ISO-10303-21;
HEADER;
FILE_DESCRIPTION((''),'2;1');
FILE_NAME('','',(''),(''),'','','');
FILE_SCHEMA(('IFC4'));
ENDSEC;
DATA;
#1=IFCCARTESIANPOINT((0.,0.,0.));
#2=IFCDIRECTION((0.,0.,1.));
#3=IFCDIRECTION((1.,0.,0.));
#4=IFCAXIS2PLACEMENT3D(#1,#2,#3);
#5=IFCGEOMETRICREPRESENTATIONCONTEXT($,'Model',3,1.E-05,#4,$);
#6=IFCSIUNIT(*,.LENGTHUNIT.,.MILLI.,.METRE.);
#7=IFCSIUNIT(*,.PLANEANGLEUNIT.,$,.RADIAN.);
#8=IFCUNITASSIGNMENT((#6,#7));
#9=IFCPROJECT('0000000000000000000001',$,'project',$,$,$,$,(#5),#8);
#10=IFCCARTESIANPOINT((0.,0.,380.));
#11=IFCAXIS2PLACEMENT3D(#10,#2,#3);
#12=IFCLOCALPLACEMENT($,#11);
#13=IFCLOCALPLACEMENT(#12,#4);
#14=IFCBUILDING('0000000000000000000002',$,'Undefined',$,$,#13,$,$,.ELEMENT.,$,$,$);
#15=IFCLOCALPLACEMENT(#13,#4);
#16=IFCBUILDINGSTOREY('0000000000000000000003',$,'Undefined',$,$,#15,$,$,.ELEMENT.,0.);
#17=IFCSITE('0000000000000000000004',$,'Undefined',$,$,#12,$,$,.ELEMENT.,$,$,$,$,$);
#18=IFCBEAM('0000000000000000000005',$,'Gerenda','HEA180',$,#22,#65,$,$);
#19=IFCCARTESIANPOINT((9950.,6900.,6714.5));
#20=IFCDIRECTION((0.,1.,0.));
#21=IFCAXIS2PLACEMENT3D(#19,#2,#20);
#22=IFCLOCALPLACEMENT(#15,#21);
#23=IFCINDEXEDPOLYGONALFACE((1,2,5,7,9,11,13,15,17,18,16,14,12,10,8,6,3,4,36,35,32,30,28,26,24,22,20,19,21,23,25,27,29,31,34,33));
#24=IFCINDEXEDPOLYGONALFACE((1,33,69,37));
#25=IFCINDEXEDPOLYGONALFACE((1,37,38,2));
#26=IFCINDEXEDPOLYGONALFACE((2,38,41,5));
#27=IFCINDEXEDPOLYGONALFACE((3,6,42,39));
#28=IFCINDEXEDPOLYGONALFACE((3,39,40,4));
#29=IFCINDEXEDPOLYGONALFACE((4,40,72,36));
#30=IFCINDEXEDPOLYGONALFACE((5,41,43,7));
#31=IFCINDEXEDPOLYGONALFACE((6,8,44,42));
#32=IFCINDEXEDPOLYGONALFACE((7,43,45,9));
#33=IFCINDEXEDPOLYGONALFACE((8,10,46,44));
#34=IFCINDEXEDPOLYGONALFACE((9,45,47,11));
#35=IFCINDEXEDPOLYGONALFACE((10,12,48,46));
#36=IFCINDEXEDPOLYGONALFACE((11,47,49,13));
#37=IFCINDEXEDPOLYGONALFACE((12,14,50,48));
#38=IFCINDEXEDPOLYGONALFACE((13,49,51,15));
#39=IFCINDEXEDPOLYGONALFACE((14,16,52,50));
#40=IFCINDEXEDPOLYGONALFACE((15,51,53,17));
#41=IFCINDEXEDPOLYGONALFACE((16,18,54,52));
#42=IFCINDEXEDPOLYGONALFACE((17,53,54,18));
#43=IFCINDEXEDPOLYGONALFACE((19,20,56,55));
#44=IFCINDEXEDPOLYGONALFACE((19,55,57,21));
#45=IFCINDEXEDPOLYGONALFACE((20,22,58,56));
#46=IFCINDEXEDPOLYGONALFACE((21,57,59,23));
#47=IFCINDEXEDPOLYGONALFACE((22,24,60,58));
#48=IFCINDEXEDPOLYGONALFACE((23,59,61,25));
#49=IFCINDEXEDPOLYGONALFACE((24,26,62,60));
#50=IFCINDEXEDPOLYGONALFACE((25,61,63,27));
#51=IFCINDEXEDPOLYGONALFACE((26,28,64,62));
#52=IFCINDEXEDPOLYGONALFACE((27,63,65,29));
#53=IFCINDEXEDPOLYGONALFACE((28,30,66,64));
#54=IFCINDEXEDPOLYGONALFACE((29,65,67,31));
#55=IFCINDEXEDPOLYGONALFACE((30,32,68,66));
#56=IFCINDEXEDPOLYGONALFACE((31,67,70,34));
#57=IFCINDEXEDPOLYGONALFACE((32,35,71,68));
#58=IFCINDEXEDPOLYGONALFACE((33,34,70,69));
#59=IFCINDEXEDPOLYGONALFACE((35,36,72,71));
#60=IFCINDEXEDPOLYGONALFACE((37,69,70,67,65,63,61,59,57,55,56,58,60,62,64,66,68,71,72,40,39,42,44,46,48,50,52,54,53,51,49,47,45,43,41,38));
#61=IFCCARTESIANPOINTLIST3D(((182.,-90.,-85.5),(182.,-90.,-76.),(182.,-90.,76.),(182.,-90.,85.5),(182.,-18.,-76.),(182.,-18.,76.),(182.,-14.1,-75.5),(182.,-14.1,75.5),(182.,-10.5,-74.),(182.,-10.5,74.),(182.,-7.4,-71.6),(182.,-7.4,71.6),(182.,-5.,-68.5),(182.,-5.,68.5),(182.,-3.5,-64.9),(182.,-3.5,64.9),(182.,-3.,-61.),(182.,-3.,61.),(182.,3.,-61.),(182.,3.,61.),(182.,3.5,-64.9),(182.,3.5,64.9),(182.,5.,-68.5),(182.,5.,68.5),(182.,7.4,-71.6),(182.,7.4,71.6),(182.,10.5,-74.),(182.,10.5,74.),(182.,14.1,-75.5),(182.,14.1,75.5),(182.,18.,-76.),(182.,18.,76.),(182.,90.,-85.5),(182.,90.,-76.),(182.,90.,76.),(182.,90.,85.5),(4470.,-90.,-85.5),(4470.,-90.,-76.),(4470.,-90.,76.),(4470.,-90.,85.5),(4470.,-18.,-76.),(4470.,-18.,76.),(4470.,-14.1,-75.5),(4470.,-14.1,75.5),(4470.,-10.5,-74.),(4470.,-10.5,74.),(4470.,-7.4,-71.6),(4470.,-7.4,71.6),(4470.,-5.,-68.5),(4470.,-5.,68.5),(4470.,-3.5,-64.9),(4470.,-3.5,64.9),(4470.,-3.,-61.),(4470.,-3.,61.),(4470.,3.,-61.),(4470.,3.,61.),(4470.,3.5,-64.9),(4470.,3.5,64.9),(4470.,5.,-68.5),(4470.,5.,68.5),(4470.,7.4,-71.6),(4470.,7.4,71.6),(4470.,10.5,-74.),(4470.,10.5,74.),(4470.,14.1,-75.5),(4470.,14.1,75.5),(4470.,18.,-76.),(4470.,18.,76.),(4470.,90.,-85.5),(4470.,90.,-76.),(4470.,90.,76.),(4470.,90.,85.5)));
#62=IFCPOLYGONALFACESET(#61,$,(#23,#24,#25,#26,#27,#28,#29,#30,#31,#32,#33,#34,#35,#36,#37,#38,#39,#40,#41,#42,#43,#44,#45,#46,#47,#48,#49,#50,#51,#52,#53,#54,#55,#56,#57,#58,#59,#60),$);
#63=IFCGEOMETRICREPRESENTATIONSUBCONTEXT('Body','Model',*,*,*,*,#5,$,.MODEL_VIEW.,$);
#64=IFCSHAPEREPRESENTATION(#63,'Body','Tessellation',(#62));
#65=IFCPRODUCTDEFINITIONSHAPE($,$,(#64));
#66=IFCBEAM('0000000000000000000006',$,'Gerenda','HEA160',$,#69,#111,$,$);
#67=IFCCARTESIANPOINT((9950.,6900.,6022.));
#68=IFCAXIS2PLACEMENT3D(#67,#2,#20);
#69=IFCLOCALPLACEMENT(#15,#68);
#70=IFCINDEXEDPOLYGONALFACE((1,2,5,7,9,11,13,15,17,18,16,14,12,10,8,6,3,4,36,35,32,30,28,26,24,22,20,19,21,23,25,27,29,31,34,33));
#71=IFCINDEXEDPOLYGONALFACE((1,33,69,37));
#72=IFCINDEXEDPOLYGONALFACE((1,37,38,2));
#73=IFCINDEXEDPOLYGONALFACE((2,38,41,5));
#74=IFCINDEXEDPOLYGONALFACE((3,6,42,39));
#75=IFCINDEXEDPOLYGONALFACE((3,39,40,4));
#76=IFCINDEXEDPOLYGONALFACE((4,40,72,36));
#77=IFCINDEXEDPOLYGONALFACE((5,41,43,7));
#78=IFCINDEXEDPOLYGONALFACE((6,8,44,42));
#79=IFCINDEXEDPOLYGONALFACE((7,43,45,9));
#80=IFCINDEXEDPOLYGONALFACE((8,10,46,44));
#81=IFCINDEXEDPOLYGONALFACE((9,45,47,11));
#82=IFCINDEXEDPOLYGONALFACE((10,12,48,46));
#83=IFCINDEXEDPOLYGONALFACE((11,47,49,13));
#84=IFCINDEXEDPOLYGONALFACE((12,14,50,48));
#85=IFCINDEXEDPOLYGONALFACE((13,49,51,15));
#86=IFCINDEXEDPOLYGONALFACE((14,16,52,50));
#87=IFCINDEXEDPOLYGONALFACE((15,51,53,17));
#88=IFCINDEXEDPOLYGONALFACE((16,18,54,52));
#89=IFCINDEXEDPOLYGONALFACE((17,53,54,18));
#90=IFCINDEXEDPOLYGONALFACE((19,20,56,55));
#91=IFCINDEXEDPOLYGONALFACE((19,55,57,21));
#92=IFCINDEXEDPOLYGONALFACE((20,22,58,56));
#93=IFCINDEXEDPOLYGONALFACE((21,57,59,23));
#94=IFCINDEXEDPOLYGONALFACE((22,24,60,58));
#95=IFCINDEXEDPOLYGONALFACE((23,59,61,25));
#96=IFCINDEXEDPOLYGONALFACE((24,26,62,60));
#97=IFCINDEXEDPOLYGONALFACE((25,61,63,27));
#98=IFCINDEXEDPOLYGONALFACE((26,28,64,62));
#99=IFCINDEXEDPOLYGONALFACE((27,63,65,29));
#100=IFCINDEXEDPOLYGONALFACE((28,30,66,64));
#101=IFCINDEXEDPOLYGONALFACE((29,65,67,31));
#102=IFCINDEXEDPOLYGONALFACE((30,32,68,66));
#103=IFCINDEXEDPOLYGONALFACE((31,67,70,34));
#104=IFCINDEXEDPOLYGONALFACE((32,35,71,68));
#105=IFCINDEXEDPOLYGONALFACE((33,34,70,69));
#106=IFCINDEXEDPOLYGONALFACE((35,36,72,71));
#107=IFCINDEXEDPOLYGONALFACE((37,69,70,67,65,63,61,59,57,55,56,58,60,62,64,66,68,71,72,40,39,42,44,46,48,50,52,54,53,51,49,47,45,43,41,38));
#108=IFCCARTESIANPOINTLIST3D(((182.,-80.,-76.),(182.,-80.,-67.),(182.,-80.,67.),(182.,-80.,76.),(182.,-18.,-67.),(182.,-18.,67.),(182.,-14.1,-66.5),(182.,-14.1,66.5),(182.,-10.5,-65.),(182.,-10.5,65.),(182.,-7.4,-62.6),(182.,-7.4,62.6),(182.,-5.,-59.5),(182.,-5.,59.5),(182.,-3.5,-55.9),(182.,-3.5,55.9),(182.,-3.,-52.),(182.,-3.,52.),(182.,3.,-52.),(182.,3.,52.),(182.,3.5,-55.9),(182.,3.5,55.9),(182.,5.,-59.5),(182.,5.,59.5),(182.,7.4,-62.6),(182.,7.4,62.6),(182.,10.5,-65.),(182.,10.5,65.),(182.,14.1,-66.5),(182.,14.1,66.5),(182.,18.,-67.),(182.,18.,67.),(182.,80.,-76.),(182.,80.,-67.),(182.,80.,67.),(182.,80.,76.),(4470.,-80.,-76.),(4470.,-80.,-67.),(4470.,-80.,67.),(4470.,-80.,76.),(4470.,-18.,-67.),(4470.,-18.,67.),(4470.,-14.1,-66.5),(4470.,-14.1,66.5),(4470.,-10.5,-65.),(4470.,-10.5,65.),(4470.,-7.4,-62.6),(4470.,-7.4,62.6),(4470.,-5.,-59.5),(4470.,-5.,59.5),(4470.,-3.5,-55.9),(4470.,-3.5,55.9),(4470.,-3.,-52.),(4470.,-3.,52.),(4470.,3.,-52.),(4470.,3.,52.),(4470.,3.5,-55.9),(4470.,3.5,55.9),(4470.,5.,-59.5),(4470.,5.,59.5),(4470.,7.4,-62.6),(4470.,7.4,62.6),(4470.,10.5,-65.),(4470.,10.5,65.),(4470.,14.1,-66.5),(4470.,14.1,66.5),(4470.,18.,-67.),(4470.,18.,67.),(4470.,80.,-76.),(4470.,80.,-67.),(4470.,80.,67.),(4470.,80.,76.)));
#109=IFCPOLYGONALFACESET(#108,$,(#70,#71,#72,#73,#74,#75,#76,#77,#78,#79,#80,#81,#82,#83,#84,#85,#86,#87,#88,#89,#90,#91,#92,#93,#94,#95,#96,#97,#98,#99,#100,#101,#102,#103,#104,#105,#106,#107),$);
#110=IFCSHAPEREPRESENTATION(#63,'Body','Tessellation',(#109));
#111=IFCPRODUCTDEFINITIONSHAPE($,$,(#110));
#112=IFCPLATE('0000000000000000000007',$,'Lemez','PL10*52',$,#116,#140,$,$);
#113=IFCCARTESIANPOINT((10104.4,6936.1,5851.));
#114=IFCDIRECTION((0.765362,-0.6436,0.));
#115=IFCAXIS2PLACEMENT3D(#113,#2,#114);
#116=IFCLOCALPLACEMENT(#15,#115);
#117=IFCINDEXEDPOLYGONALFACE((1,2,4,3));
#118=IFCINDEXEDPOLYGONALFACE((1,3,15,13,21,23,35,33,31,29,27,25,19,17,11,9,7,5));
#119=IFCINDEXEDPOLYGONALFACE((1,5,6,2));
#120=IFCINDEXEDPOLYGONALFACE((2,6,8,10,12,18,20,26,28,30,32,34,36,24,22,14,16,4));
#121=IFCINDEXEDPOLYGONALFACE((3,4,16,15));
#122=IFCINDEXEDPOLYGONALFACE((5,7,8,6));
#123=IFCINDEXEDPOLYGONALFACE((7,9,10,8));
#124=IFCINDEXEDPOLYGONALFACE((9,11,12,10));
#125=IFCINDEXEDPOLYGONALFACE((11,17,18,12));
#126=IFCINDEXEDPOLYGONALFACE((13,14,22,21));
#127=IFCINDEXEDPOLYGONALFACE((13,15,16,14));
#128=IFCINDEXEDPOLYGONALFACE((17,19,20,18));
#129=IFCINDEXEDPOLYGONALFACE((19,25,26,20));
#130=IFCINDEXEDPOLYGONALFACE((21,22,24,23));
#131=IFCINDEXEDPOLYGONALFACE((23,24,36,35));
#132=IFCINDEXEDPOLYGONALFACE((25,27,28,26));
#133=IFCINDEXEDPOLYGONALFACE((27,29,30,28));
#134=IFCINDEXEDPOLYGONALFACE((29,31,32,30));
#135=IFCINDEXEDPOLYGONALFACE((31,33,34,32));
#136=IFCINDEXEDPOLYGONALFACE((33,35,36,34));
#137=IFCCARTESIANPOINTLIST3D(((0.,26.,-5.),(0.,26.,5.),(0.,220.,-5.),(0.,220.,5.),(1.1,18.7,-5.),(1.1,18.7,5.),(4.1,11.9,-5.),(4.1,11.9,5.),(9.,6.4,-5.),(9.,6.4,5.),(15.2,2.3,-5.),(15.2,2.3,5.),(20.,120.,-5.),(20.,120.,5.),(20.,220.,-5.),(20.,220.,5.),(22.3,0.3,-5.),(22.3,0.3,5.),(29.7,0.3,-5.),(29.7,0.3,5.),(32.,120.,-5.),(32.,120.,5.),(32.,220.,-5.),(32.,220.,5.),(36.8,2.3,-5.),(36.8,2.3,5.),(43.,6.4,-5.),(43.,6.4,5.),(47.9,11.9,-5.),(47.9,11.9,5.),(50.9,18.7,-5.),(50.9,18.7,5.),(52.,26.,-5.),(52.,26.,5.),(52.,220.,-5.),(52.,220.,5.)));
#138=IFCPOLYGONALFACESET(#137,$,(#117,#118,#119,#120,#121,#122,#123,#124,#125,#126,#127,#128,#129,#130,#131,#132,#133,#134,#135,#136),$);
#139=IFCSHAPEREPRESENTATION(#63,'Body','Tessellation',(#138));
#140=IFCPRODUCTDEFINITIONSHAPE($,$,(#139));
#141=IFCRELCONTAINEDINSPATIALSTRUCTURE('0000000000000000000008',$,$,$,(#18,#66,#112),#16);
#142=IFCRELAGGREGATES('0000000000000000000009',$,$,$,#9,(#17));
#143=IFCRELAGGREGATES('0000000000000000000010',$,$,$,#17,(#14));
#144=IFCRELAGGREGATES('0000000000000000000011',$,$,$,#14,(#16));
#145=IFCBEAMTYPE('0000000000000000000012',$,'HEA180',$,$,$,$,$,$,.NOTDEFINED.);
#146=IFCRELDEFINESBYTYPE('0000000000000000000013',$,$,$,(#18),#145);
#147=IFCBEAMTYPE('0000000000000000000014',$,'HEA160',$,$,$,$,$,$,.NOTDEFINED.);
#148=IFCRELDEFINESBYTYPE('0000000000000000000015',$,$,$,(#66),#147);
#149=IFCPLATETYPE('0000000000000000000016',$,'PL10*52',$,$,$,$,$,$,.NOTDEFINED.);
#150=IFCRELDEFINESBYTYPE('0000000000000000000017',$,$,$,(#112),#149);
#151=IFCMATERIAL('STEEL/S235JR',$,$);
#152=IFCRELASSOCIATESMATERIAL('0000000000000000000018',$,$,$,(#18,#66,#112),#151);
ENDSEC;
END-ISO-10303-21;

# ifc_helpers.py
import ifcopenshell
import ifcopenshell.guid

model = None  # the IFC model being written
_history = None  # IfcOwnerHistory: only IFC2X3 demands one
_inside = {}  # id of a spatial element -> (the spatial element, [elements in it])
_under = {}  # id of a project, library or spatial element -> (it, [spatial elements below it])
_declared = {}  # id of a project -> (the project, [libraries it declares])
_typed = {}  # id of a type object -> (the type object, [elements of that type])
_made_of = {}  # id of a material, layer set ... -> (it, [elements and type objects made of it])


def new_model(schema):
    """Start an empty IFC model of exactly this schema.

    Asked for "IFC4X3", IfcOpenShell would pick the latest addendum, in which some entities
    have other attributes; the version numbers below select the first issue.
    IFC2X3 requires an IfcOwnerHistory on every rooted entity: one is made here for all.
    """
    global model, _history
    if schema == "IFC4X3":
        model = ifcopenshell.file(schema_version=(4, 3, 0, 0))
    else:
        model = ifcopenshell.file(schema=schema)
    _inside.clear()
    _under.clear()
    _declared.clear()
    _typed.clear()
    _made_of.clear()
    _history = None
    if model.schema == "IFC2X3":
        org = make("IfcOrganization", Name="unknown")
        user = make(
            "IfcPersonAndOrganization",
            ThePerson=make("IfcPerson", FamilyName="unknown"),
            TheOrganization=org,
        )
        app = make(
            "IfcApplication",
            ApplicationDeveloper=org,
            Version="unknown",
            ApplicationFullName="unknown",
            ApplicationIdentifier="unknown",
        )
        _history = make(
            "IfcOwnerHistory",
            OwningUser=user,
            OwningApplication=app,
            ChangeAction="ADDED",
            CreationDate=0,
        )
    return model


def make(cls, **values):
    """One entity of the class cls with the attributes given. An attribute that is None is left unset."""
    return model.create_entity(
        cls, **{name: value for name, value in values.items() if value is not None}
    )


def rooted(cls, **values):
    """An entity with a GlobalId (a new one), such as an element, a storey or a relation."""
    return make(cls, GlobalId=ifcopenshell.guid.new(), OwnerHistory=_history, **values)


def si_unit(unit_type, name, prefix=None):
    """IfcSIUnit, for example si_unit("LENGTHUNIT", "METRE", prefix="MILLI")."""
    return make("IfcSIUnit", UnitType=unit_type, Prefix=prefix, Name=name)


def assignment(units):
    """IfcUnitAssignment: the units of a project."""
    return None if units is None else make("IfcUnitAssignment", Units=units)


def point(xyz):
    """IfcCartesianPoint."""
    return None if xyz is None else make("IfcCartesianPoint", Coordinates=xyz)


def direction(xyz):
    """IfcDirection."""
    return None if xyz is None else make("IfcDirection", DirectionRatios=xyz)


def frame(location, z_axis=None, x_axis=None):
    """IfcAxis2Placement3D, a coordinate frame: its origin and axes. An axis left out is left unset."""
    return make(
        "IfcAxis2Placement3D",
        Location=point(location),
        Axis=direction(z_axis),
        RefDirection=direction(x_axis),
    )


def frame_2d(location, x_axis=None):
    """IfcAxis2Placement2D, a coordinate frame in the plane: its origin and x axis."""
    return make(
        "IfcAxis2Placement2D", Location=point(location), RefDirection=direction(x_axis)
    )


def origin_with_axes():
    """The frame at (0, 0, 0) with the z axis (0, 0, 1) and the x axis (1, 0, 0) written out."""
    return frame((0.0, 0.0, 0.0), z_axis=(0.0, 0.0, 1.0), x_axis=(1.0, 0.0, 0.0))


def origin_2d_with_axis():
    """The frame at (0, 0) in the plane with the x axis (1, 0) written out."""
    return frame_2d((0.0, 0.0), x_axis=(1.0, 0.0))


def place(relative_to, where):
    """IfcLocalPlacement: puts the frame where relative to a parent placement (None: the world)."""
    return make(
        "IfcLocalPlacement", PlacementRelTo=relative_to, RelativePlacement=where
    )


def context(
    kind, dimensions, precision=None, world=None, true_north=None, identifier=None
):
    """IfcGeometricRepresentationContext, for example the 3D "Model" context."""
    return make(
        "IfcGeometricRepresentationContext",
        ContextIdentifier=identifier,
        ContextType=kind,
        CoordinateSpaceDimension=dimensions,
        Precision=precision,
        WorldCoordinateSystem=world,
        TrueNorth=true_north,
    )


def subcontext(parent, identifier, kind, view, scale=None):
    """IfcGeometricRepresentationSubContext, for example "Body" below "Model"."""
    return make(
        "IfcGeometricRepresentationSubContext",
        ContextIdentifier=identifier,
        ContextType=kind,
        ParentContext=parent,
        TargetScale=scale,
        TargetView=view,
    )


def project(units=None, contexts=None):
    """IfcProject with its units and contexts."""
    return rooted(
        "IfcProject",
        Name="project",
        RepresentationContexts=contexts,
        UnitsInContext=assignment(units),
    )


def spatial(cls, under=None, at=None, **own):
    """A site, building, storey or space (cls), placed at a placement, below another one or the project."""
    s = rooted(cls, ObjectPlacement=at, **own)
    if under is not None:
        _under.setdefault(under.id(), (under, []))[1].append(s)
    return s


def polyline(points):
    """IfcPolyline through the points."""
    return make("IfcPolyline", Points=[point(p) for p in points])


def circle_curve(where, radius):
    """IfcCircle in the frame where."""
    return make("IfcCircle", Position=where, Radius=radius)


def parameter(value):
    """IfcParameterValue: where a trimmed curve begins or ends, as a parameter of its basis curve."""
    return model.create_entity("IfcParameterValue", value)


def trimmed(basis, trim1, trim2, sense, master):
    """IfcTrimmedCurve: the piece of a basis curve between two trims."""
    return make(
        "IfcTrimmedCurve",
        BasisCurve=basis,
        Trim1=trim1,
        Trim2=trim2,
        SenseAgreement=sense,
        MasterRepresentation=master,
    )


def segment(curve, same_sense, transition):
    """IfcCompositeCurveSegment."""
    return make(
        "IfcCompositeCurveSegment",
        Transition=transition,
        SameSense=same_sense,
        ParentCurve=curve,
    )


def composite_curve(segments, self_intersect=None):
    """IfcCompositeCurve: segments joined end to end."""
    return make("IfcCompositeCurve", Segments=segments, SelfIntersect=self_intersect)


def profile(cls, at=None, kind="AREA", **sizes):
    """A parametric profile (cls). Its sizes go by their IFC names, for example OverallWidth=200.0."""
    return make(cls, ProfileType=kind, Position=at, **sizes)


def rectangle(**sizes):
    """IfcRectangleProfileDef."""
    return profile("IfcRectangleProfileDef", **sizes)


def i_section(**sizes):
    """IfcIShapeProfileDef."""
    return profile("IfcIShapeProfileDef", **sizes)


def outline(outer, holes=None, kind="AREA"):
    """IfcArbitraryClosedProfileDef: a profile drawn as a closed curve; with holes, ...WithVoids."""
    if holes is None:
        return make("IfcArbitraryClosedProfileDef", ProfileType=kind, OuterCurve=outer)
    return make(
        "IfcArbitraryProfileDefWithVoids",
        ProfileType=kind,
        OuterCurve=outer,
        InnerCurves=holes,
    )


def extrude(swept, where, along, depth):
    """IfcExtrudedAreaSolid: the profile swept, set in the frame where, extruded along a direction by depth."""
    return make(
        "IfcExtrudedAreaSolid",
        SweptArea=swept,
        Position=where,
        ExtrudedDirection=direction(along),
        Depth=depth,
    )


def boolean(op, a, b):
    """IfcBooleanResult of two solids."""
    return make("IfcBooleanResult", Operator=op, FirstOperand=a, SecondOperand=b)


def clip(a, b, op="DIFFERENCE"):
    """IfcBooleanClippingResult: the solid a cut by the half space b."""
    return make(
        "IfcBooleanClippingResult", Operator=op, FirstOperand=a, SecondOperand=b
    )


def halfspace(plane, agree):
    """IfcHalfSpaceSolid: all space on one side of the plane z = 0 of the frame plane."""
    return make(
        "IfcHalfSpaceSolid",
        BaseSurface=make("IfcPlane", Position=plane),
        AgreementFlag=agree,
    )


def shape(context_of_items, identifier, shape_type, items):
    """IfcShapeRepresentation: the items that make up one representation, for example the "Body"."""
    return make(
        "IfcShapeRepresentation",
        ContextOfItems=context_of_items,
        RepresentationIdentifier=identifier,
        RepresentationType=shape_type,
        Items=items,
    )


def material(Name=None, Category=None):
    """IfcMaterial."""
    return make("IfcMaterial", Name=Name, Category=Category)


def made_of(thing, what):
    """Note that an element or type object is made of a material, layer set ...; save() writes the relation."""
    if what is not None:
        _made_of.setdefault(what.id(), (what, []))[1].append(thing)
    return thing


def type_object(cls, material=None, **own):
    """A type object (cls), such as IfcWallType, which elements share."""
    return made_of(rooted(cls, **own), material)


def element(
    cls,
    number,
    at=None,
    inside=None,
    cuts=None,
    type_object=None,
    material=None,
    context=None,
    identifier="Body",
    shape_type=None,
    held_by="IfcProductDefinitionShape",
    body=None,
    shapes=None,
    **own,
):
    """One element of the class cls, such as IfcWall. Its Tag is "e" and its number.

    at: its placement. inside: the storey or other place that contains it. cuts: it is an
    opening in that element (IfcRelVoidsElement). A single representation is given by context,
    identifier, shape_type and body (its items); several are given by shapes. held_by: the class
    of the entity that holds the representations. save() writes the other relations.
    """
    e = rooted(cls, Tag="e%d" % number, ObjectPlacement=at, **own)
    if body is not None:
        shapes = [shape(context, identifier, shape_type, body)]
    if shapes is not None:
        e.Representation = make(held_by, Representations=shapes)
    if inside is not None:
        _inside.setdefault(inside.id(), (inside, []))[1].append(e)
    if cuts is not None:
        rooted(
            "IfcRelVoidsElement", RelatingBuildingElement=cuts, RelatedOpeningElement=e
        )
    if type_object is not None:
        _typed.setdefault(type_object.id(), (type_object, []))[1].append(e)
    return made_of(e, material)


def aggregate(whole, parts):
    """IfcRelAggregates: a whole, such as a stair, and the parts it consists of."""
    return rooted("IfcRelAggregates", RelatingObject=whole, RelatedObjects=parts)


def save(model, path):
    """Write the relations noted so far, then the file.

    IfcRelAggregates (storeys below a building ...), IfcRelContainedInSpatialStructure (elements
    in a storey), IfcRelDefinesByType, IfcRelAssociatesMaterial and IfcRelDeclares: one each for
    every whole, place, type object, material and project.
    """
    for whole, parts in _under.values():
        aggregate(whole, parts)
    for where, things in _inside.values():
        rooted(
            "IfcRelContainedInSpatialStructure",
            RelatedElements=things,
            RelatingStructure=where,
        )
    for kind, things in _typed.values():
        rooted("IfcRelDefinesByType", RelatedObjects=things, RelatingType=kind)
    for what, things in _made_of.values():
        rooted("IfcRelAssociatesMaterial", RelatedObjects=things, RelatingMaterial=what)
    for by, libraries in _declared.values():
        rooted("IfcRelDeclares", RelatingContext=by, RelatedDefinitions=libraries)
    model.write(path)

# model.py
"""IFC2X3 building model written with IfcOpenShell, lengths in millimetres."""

from ifc_helpers import new_model, si_unit, frame, frame_2d, origin_with_axes, origin_2d_with_axis, place, context, subcontext, project, spatial, polyline, circle_curve, parameter, trimmed, segment, composite_curve, rectangle, i_section, outline, extrude, boolean, clip, halfspace, material, type_object, element, save


model = new_model("IFC2X3")

# Units and contexts
model_context = context("Model", 3, precision=1e-05, world=origin_with_axes())
body_context = subcontext(model_context, "Body", "Model", "MODEL_VIEW")
ifc_project = project(units=[si_unit("LENGTHUNIT", "METRE", prefix="MILLI"), si_unit("PLANEANGLEUNIT", "RADIAN")], contexts=[model_context])

# Site, building, storey
site_placement = place(None, frame((0.0, 0.0, 380.0), z_axis=(0.0, 0.0, 1.0), x_axis=(1.0, 0.0, 0.0)))
site = spatial("IfcSite", under=ifc_project, at=site_placement, Name="Undefined", CompositionType="ELEMENT")
building_placement = place(site_placement, origin_with_axes())
building = spatial("IfcBuilding", under=site, at=building_placement, Name="Undefined", CompositionType="ELEMENT")
storey_placement = place(building_placement, origin_with_axes())
storey = spatial("IfcBuildingStorey", under=building, at=storey_placement, Name="Undefined", CompositionType="ELEMENT", Elevation=0.0)

# Shared definitions
ifc_material_1 = material(Name="STEEL/S235JR")

# Beams
beam_type_1 = type_object("IfcBeamType", Name="HEA180", PredefinedType="NOTDEFINED")
beam_1_placement = place(storey_placement, frame((9950.0, 6900.0, 6714.5), z_axis=(0.0, 0.0, 1.0), x_axis=(0.0, 1.0, 0.0)))
element("IfcBeam", 1, at=beam_1_placement, inside=storey, type_object=beam_type_1, material=ifc_material_1, Name="Gerenda", Description="HEA180", context=body_context, shape_type="Clipping", body=[
    clip(extrude(i_section(OverallWidth=180.0, OverallDepth=171.0, WebThickness=6.0, FlangeThickness=9.5, FilletRadius=15.0, at=origin_2d_with_axis()), frame((4470.0, 0.0, 0.0), z_axis=(-1.0, 0.0, 0.0), x_axis=(0.0, -1.0, 0.0)), (0.0, 0.0, 1.0), 4470.0), halfspace(frame((182.0, 0.0, 85.5), z_axis=(1.0, 0.0, 0.0), x_axis=(0.0, 1.0, 0.0)), True)),
])
beam_type_2 = type_object("IfcBeamType", Name="HEA160", PredefinedType="NOTDEFINED")
beam_2_placement = place(storey_placement, frame((9950.0, 6900.0, 6022.0), z_axis=(0.0, 0.0, 1.0), x_axis=(0.0, 1.0, 0.0)))
element("IfcBeam", 2, at=beam_2_placement, inside=storey, type_object=beam_type_2, material=ifc_material_1, Name="Gerenda", Description="HEA160", context=body_context, shape_type="Clipping", body=[
    clip(extrude(i_section(OverallWidth=160.0, OverallDepth=152.0, WebThickness=6.0, FlangeThickness=9.0, FilletRadius=15.0, at=origin_2d_with_axis()), frame((4470.0, 0.0, 0.0), z_axis=(-1.0, 0.0, 0.0), x_axis=(0.0, -1.0, 0.0)), (0.0, 0.0, 1.0), 4470.0), halfspace(frame((182.0, 0.0, 76.0), z_axis=(1.0, 0.0, 0.0), x_axis=(0.0, 1.0, 0.0)), True)),
])

# Plate
plate_type_1 = type_object("IfcPlateType", Name="PL10*52", PredefinedType="NOTDEFINED")
plate_1_placement = place(storey_placement, frame((10104.4, 6936.1, 5851.0), z_axis=(0.0, 0.0, 1.0), x_axis=(0.765362, -0.6436, 0.0)))
element("IfcPlate", 3, at=plate_1_placement, inside=storey, type_object=plate_type_1, material=ifc_material_1, Name="Lemez", Description="PL10*52", context=body_context, shape_type="CSG", body=[
    boolean("DIFFERENCE", extrude(outline(composite_curve([segment(trimmed(circle_curve(frame_2d((26.0, 26.0), x_axis=(-1.0, 0.0)), 26.0), [parameter(0.0)], [parameter(1.570796)], True, "PARAMETER"), True, "CONTINUOUS"), segment(trimmed(circle_curve(frame_2d((26.0, 26.0), x_axis=(0.0, -1.0)), 26.0), [parameter(0.0)], [parameter(1.570796)], True, "PARAMETER"), True, "CONTINUOUS"), segment(polyline([(52.0, 26.0), (52.0, 220.0), (0.0, 220.0), (0.0, 26.0)]), True, "CONTINUOUS")], self_intersect=True)), frame((0.0, 0.0, -5.0), z_axis=(0.0, 0.0, 1.0), x_axis=(1.0, 0.0, 0.0)), (0.0, 0.0, 1.0), 10.0), extrude(rectangle(XDim=12.0, YDim=12.0, at=origin_2d_with_axis()), frame((26.0, 320.0, 0.0), z_axis=(0.0, -1.0, 0.0), x_axis=(1.0, 0.0, 0.0)), (0.0, 0.0, 1.0), 200.0)),
])

save(model, "model.ifc")
